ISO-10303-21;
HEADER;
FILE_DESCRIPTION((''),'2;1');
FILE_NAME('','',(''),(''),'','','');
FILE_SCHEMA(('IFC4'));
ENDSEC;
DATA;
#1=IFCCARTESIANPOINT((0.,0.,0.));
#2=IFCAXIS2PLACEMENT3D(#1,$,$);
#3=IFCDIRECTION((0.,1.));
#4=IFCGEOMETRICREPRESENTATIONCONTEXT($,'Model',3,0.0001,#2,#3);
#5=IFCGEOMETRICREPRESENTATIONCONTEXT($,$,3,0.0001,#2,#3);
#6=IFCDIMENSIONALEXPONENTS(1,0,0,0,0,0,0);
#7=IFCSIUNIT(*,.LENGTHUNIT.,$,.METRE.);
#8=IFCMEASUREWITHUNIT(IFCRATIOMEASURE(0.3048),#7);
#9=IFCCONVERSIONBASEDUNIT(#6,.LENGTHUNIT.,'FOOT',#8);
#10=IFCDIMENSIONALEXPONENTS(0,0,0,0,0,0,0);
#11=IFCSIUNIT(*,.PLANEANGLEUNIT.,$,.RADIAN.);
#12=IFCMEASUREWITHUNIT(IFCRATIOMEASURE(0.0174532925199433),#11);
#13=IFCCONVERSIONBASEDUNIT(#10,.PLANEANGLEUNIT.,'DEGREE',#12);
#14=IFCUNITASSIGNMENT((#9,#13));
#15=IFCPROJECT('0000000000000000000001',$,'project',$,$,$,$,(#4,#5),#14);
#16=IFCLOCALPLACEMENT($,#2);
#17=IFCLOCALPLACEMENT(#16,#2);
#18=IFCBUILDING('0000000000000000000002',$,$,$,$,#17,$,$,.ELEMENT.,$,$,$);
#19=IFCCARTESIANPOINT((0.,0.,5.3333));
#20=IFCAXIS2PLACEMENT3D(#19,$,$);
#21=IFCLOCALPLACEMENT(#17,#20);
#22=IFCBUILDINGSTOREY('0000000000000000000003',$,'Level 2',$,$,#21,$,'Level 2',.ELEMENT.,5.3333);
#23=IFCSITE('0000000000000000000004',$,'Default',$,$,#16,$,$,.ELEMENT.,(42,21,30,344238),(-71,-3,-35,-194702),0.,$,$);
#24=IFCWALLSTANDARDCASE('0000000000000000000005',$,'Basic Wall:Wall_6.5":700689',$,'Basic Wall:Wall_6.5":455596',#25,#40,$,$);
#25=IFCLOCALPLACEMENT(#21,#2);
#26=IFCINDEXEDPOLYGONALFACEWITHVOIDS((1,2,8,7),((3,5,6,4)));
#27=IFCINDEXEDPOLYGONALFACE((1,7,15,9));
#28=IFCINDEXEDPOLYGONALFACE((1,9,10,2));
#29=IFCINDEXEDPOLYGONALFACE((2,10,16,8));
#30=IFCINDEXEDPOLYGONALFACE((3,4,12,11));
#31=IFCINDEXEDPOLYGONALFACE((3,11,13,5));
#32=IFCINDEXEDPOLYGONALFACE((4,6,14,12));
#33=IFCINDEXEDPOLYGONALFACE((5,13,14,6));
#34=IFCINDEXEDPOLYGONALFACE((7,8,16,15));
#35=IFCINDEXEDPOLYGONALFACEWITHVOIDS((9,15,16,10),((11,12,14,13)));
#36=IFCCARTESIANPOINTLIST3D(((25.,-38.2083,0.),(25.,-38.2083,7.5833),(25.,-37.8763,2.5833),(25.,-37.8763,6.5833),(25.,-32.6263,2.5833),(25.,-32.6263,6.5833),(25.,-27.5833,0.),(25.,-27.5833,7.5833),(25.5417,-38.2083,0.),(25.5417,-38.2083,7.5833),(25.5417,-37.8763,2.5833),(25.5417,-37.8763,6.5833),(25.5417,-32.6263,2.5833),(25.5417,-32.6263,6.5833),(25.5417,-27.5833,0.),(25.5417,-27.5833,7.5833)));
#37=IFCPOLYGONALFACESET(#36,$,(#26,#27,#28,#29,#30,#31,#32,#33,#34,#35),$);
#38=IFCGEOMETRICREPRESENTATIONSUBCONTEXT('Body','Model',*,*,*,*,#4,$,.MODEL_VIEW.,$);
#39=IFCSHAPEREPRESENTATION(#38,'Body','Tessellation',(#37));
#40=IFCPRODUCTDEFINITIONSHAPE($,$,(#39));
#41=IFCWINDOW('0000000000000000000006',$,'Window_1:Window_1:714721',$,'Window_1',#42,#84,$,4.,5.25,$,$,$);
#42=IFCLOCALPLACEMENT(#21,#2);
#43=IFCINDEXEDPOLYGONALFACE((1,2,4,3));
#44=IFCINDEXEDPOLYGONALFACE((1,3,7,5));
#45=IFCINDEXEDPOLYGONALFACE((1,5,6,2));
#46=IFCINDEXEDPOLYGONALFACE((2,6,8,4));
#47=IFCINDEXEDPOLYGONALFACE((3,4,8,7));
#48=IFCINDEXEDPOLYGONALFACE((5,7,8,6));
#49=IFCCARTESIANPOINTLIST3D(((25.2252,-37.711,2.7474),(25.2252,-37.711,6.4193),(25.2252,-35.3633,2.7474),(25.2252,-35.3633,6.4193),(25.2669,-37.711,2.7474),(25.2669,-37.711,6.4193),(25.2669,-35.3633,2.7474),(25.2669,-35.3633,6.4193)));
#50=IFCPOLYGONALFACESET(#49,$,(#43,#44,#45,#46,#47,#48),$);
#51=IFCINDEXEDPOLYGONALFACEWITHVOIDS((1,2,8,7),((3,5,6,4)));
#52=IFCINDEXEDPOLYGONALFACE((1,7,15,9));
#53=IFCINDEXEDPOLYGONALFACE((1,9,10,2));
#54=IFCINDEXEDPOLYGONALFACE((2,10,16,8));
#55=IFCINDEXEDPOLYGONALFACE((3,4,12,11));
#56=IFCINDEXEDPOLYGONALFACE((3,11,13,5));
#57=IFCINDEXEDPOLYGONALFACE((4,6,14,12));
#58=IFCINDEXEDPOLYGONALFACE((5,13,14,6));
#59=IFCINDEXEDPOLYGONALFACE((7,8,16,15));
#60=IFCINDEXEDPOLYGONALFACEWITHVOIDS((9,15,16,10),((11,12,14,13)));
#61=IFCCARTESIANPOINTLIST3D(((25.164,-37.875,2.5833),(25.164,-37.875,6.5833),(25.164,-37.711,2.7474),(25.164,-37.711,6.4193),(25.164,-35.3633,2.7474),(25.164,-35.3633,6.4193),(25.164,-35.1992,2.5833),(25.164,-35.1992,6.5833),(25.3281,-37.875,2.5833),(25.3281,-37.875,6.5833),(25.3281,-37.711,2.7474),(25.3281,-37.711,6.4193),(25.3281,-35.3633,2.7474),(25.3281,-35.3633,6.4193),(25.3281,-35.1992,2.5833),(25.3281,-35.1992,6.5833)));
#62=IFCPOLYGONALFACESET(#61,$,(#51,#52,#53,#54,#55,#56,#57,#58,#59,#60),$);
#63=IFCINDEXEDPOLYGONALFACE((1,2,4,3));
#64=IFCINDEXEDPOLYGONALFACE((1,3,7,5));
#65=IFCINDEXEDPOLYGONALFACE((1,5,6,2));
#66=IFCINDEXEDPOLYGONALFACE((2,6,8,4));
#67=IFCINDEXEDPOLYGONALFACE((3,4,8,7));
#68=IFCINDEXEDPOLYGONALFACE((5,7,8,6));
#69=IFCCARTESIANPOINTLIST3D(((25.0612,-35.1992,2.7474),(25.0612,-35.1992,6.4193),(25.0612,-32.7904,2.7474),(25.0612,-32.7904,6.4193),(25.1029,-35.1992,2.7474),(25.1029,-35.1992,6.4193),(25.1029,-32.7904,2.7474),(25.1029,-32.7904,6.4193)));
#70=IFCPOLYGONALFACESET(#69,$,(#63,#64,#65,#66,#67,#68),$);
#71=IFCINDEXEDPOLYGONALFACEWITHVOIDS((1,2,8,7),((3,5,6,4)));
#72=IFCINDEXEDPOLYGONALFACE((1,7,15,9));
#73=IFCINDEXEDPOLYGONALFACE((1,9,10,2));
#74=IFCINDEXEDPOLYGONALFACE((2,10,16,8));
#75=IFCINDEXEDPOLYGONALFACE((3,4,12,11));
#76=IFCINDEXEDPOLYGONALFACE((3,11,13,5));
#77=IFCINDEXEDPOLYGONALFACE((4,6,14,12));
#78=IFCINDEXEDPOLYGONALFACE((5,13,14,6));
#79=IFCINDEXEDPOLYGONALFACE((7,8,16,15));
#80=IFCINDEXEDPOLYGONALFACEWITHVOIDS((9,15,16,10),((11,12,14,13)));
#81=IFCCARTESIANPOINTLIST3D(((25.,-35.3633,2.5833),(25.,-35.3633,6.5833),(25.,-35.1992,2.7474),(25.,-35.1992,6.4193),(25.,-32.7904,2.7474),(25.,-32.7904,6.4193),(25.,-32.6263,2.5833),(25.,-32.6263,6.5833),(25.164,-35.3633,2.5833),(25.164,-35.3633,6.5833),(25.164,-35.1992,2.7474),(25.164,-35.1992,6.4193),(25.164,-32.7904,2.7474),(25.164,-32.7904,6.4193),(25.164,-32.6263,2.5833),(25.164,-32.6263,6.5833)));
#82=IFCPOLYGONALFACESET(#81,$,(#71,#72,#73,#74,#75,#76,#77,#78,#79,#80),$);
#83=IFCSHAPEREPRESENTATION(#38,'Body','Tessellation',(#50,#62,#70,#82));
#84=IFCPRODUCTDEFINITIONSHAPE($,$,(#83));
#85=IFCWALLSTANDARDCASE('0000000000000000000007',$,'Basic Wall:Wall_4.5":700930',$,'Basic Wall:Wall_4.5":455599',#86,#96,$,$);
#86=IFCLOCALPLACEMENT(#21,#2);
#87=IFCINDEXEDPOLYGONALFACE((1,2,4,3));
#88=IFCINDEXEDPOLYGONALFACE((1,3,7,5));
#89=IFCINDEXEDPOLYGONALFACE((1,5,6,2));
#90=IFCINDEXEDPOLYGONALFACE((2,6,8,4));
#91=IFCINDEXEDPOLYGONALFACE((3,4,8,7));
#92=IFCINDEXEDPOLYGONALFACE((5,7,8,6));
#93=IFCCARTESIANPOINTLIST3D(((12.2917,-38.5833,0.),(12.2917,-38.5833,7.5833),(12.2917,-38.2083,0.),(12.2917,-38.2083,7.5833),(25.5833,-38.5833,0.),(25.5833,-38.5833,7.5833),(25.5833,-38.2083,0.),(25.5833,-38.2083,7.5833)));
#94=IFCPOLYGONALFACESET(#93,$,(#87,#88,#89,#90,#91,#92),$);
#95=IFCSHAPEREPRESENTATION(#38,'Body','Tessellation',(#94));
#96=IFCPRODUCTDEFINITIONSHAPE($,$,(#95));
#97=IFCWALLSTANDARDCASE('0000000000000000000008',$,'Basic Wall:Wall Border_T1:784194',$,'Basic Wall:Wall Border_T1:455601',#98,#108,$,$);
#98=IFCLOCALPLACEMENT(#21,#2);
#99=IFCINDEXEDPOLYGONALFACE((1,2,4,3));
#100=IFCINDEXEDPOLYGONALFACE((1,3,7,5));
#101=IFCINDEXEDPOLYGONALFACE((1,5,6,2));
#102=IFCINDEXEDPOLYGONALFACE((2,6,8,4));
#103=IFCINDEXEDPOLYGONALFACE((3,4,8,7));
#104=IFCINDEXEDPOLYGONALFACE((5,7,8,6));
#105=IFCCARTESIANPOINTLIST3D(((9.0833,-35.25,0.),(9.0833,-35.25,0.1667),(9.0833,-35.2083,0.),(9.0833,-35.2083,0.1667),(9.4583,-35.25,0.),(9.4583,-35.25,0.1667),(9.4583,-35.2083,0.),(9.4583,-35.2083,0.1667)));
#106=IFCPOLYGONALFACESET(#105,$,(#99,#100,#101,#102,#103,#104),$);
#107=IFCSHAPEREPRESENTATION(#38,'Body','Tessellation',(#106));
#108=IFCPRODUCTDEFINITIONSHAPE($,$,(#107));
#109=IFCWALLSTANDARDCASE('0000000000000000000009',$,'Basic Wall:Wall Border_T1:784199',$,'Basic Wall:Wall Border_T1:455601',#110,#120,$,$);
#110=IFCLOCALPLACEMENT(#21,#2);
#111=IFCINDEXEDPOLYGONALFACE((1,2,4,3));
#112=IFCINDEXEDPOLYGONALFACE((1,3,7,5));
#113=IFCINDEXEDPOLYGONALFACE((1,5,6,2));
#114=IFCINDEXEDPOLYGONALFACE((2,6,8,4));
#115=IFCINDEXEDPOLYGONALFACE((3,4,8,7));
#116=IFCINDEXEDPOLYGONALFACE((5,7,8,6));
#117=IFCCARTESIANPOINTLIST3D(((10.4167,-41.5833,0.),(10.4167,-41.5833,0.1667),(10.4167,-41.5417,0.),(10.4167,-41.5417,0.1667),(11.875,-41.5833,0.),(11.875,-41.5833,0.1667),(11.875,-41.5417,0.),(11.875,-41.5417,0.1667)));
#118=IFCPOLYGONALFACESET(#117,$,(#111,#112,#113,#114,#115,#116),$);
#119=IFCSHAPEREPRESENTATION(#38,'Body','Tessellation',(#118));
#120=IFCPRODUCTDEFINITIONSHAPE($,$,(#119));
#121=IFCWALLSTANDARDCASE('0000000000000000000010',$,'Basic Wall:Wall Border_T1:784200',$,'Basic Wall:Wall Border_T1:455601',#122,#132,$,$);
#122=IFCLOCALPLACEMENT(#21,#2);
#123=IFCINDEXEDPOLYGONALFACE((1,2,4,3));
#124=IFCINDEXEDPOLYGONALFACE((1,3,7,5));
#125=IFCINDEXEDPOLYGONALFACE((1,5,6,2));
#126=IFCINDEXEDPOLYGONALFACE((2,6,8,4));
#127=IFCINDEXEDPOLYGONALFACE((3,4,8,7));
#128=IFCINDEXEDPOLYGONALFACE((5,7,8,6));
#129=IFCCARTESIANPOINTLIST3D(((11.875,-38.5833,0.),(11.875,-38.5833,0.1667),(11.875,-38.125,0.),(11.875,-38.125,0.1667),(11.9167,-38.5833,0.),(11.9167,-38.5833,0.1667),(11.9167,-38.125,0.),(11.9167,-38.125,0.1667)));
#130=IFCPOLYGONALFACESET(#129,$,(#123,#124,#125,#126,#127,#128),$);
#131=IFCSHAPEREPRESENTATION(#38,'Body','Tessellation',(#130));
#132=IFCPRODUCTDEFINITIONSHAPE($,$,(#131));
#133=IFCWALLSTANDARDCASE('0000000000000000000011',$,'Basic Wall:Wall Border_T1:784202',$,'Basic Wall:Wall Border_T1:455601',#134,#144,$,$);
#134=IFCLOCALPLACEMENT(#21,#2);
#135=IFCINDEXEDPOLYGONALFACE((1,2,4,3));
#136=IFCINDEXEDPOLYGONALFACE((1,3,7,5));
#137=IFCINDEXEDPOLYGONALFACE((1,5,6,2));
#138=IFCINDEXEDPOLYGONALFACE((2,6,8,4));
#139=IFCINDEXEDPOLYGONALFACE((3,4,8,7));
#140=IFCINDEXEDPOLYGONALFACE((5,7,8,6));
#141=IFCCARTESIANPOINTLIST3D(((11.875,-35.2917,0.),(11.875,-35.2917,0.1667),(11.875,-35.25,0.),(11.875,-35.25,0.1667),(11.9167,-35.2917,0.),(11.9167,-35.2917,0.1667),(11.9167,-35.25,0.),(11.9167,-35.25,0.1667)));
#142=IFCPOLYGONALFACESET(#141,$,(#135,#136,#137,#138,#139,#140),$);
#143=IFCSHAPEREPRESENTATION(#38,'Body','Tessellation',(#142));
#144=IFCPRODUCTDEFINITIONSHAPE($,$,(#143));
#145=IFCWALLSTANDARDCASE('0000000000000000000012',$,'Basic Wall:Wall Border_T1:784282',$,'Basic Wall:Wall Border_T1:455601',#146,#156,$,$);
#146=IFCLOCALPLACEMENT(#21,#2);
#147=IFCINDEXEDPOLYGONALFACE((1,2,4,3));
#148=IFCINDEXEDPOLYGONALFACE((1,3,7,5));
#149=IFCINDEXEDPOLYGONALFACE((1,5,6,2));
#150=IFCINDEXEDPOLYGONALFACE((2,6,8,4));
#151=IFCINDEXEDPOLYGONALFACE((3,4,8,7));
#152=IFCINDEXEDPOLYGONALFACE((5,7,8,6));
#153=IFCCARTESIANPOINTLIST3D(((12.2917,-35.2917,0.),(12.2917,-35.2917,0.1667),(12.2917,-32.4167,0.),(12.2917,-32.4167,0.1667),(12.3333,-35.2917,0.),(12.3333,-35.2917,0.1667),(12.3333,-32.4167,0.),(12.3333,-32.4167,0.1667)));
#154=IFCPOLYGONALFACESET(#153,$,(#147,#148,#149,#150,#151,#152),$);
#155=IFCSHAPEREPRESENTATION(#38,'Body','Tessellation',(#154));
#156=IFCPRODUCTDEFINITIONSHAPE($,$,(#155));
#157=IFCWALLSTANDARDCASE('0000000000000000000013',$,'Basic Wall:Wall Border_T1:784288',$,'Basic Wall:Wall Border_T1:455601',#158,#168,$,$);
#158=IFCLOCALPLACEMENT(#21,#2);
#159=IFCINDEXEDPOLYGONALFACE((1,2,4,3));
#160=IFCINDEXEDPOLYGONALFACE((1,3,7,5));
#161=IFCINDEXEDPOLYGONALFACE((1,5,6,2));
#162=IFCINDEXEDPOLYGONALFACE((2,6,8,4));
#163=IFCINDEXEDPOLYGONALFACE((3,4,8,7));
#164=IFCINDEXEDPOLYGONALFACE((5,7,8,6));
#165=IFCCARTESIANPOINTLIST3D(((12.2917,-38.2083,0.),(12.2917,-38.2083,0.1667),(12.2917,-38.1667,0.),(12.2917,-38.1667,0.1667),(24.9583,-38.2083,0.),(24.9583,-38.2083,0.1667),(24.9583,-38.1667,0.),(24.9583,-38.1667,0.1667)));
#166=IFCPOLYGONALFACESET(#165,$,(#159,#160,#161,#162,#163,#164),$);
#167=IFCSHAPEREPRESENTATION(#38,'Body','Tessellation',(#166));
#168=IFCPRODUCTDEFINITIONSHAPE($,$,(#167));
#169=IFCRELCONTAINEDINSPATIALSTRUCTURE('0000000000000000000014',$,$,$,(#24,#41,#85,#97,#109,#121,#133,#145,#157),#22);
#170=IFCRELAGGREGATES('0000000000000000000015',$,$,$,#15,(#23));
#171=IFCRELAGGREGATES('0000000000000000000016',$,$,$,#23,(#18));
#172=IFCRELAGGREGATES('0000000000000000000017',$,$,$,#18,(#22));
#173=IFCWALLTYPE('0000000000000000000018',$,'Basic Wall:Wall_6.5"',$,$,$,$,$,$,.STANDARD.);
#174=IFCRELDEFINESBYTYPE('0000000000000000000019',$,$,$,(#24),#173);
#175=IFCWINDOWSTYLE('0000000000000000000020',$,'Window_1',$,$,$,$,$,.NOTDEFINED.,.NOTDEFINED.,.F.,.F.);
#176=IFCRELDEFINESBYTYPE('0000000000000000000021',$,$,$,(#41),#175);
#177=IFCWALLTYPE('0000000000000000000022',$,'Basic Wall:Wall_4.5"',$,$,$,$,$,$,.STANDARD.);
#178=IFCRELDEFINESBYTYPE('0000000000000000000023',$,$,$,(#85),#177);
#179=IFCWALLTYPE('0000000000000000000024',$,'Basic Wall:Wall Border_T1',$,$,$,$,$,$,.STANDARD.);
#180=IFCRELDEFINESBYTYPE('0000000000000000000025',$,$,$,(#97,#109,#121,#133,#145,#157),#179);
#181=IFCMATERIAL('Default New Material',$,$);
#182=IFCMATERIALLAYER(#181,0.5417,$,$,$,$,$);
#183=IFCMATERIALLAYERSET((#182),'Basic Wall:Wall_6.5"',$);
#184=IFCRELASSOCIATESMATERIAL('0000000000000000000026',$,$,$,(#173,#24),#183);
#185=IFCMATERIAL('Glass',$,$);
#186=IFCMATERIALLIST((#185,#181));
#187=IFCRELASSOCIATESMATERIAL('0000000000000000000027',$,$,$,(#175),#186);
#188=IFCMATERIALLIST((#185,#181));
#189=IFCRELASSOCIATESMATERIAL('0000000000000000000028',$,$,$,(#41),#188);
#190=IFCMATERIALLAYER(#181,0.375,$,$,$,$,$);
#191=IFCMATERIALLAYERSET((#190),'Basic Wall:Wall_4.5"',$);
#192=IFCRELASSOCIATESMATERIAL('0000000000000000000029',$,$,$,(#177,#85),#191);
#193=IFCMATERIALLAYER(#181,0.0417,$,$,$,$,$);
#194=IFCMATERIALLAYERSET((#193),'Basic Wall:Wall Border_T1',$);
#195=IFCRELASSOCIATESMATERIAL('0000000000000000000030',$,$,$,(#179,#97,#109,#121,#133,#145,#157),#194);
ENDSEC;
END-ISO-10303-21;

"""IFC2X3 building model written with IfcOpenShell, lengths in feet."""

from ifc_helpers import new_model, entity, si_unit, converted_unit, direction, frame, frame_2d, origin, origin_2d_with_axis, place, context, subcontext, project, spatial, polyline, rectangle, outline, extrude, source, transform, mapped, material, material_list, layer, layer_set, layer_usage, type_object, type_shapes, element, fill, save


model = new_model("IFC2X3")

# Units and contexts
model_context = context("Model", 3, precision=0.0001, world=origin(), true_north=direction((0.0, 1.0)))
context_of_model = context(None, 3, precision=0.0001, world=origin(), true_north=direction((0.0, 1.0)))
body_context = subcontext(model_context, "Body", "Model", "MODEL_VIEW")
ifc_project = project(units=[converted_unit("LENGTHUNIT", "FOOT", entity("IfcRatioMeasure", 0.3048), si_unit("LENGTHUNIT", "METRE"), dimensions=[1, 0, 0, 0, 0, 0, 0]), converted_unit("PLANEANGLEUNIT", "DEGREE", entity("IfcRatioMeasure", 0.0174532925199433), si_unit("PLANEANGLEUNIT", "RADIAN"), dimensions=[0, 0, 0, 0, 0, 0, 0])], contexts=[model_context, context_of_model])

# Site, building, storey
site_placement = place(None, origin())
site = spatial("IfcSite", under=ifc_project, at=site_placement, Name="Default", CompositionType="ELEMENT", RefLatitude=(42, 21, 30, 344238), RefLongitude=(-71, -3, -35, -194702), RefElevation=0.0)
building_placement = place(site_placement, origin())
building = spatial("IfcBuilding", under=site, at=building_placement, CompositionType="ELEMENT")
storey_placement = place(building_placement, frame((0.0, 0.0, 5.3333)))
storey = spatial("IfcBuildingStorey", under=building, at=storey_placement, Name="Level 2", LongName="Level 2", CompositionType="ELEMENT", Elevation=5.3333)

# Wall, opening, window
ifc_material_1 = material(Name="Default New Material")
ifc_layer_1 = layer(ifc_material_1, 0.5417)
ifc_layer_set_1 = layer_set([ifc_layer_1], Name="Basic Wall:Wall_6.5\"")
ifc_layer_usage_1 = layer_usage(ifc_layer_set_1, "AXIS2", "NEGATIVE", 0.2708)
wall_type_1 = type_object("IfcWallType", Name="Basic Wall:Wall_6.5\"", PredefinedType="STANDARD", material=ifc_layer_set_1)
wall_1_placement = place(storey_placement, frame((25.2708, -38.2083, 0.0), z_axis=(0.0, 0.0, 1.0), x_axis=(0.0, 1.0, 0.0)))
wall_1 = element("IfcWallStandardCase", 1, at=wall_1_placement, inside=storey, type_object=wall_type_1, material=ifc_layer_usage_1, Name="Basic Wall:Wall_6.5\":700689", ObjectType="Basic Wall:Wall_6.5\":455596", context=body_context, shape_type="SweptSolid", body=[
    extrude(rectangle(XDim=10.625, YDim=0.5417, at=frame_2d((5.3125, 0.0), x_axis=(-1.0, 0.0))), origin(), (0.0, 0.0, 1.0), 7.5833),
])
opening_placement = place(wall_1_placement, frame((0.332, -0.2708, 2.5833)))
opening = element("IfcOpeningElement", 2, at=opening_placement, cuts=wall_1, ObjectType="Opening", context=body_context, shape_type="SweptSolid", body=[
    extrude(rectangle(XDim=4.0, YDim=5.25, at=frame_2d((2.0, 2.625), x_axis=(-1.0, 0.0))), frame((0.0, 0.0, 0.0), z_axis=(0.0, 1.0, 0.0), x_axis=(0.0, 0.0, 1.0)), (0.0, 0.0, 1.0), 0.5417),
])
ifc_material_2 = material(Name="Glass")
ifc_material_list_1 = material_list([ifc_material_2, ifc_material_1])
ifc_material_list_2 = material_list([ifc_material_2, ifc_material_1])
window_style = type_object("IfcWindowStyle", Name="Window_1", ConstructionType="NOTDEFINED", OperationType="NOTDEFINED", ParameterTakesPrecedence=False, Sizeable=False, material=ifc_material_list_2)
shared_shape_1 = source(origin(), body_context, "Body", "SweptSolid", [
    extrude(rectangle(XDim=0.0417, YDim=2.3477, at=origin_2d_with_axis()), frame((1.3392, 0.2956, 0.164), z_axis=(0.0, 0.0, 1.0), x_axis=(0.0, -1.0, 0.0)), (0.0, 0.0, 1.0), 3.6719),
    extrude(outline(polyline([(-1.3379, -2.0), (1.3379, -2.0), (1.3379, 2.0), (-1.3379, 2.0), (-1.3379, -2.0)]), holes=[polyline([(-1.1738, -1.836), (-1.1738, 1.836), (1.1738, 1.836), (1.1738, -1.836), (-1.1738, -1.836)])]), frame((1.3392, 0.2136, 2.0), z_axis=(0.0, 1.0, 0.0), x_axis=(1.0, 0.0, 0.0)), (0.0, 0.0, 1.0), 0.164),
    extrude(rectangle(XDim=0.0417, YDim=2.4089, at=frame_2d((0.0, 0.0), x_axis=(1.0, 0.0))), frame((3.8815, 0.4596, 0.164), z_axis=(0.0, 0.0, 1.0), x_axis=(0.0, 1.0, 0.0)), (0.0, 0.0, 1.0), 3.6719),
    extrude(outline(polyline([(-1.3685, -2.0), (1.3685, -2.0), (1.3685, 2.0), (-1.3685, 2.0), (-1.3685, -2.0)]), holes=[polyline([(-1.2044, -1.836), (-1.2044, 1.836), (1.2044, 1.836), (1.2044, -1.836), (-1.2044, -1.836)])]), frame((3.8815, 0.3776, 2.0), z_axis=(0.0, 1.0, 0.0), x_axis=(1.0, 0.0, 0.0)), (0.0, 0.0, 1.0), 0.164),
])
type_shapes(window_style, [shared_shape_1])
window_placement = place(opening_placement, origin())
window = element("IfcWindow", 3, at=window_placement, inside=storey, type_object=window_style, material=ifc_material_list_1, Name="Window_1:Window_1:714721", ObjectType="Window_1", OverallHeight=4.0, OverallWidth=5.25, context=body_context, shape_type="MappedRepresentation", body=[
    mapped(shared_shape_1, transform((0.0, 0.0, 0.0), scale=1.0)),
])
fill(opening, window)

# Walls
ifc_layer_2 = layer(ifc_material_1, 0.375)
ifc_layer_set_2 = layer_set([ifc_layer_2], Name="Basic Wall:Wall_4.5\"")
ifc_layer_usage_2 = layer_usage(ifc_layer_set_2, "AXIS2", "NEGATIVE", 0.1875)
wall_type_2 = type_object("IfcWallType", Name="Basic Wall:Wall_4.5\"", PredefinedType="STANDARD", material=ifc_layer_set_2)
wall_2_placement = place(storey_placement, frame((12.2917, -38.3958, 0.0)))
element("IfcWallStandardCase", 4, at=wall_2_placement, inside=storey, type_object=wall_type_2, material=ifc_layer_usage_2, Name="Basic Wall:Wall_4.5\":700930", ObjectType="Basic Wall:Wall_4.5\":455599", context=body_context, shape_type="SweptSolid", body=[
    extrude(rectangle(XDim=13.2917, YDim=0.375, at=frame_2d((6.6458, 0.0), x_axis=(-1.0, 0.0))), origin(), (0.0, 0.0, 1.0), 7.5833),
])
ifc_layer_3 = layer(ifc_material_1, 0.0417)
ifc_layer_set_3 = layer_set([ifc_layer_3], Name="Basic Wall:Wall Border_T1")
ifc_layer_usage_3 = layer_usage(ifc_layer_set_3, "AXIS2", "POSITIVE", -0.0208)
wall_type_3 = type_object("IfcWallType", Name="Basic Wall:Wall Border_T1", PredefinedType="STANDARD", material=ifc_layer_set_3)
wall_3_placement = place(storey_placement, frame((9.0833, -35.2292, 0.0)))
element("IfcWallStandardCase", 5, at=wall_3_placement, inside=storey, type_object=wall_type_3, material=ifc_layer_usage_3, Name="Basic Wall:Wall Border_T1:784194", ObjectType="Basic Wall:Wall Border_T1:455601", context=body_context, shape_type="SweptSolid", body=[
    extrude(rectangle(XDim=0.375, YDim=0.0417, at=frame_2d((0.1875, 0.0), x_axis=(-1.0, 0.0))), origin(), (0.0, 0.0, 1.0), 0.1667),
])
ifc_layer_usage_4 = layer_usage(ifc_layer_set_3, "AXIS2", "NEGATIVE", 0.0208)
wall_4_placement = place(storey_placement, frame((10.4167, -41.5625, 0.0)))
element("IfcWallStandardCase", 6, at=wall_4_placement, inside=storey, type_object=wall_type_3, material=ifc_layer_usage_4, Name="Basic Wall:Wall Border_T1:784199", ObjectType="Basic Wall:Wall Border_T1:455601", context=body_context, shape_type="SweptSolid", body=[
    extrude(rectangle(XDim=1.4583, YDim=0.0417, at=frame_2d((0.7292, 0.0), x_axis=(-1.0, 0.0))), origin(), (0.0, 0.0, 1.0), 0.1667),
])
ifc_layer_usage_5 = layer_usage(ifc_layer_set_3, "AXIS2", "NEGATIVE", 0.0208)
wall_5_placement = place(storey_placement, frame((11.8958, -38.5833, 0.0), z_axis=(0.0, 0.0, 1.0), x_axis=(0.0, 1.0, 0.0)))
element("IfcWallStandardCase", 7, at=wall_5_placement, inside=storey, type_object=wall_type_3, material=ifc_layer_usage_5, Name="Basic Wall:Wall Border_T1:784200", ObjectType="Basic Wall:Wall Border_T1:455601", context=body_context, shape_type="SweptSolid", body=[
    extrude(rectangle(XDim=0.4583, YDim=0.0417, at=frame_2d((0.2292, 0.0), x_axis=(-1.0, 0.0))), origin(), (0.0, 0.0, 1.0), 0.1667),
])
ifc_layer_usage_6 = layer_usage(ifc_layer_set_3, "AXIS2", "POSITIVE", -0.0208)
wall_6_placement = place(storey_placement, frame((11.8958, -35.25, 0.0), z_axis=(0.0, 0.0, 1.0), x_axis=(0.0, -1.0, 0.0)))
element("IfcWallStandardCase", 8, at=wall_6_placement, inside=storey, type_object=wall_type_3, material=ifc_layer_usage_6, Name="Basic Wall:Wall Border_T1:784202", ObjectType="Basic Wall:Wall Border_T1:455601", context=body_context, shape_type="SweptSolid", body=[
    extrude(rectangle(XDim=0.0417, YDim=0.0417, at=frame_2d((0.0208, 0.0), x_axis=(-1.0, 0.0))), origin(), (0.0, 0.0, 1.0), 0.1667),
])
ifc_layer_usage_7 = layer_usage(ifc_layer_set_3, "AXIS2", "POSITIVE", -0.0208)
wall_7_placement = place(storey_placement, frame((12.3125, -35.2917, 0.0), z_axis=(0.0, 0.0, 1.0), x_axis=(0.0, 1.0, 0.0)))
element("IfcWallStandardCase", 9, at=wall_7_placement, inside=storey, type_object=wall_type_3, material=ifc_layer_usage_7, Name="Basic Wall:Wall Border_T1:784282", ObjectType="Basic Wall:Wall Border_T1:455601", context=body_context, shape_type="SweptSolid", body=[
    extrude(rectangle(XDim=2.875, YDim=0.0417, at=frame_2d((1.4375, 0.0), x_axis=(-1.0, 0.0))), origin(), (0.0, 0.0, 1.0), 0.1667),
])
ifc_layer_usage_8 = layer_usage(ifc_layer_set_3, "AXIS2", "POSITIVE", -0.0208)
wall_8_placement = place(storey_placement, frame((24.9583, -38.1875, 0.0), z_axis=(0.0, 0.0, 1.0), x_axis=(-1.0, 0.0, 0.0)))
element("IfcWallStandardCase", 10, at=wall_8_placement, inside=storey, type_object=wall_type_3, material=ifc_layer_usage_8, Name="Basic Wall:Wall Border_T1:784288", ObjectType="Basic Wall:Wall Border_T1:455601", context=body_context, shape_type="SweptSolid", body=[
    extrude(rectangle(XDim=12.6667, YDim=0.0417, at=frame_2d((6.3333, 0.0), x_axis=(-1.0, 0.0))), origin(), (0.0, 0.0, 1.0), 0.1667),
])

save(model, "model.ifc")
